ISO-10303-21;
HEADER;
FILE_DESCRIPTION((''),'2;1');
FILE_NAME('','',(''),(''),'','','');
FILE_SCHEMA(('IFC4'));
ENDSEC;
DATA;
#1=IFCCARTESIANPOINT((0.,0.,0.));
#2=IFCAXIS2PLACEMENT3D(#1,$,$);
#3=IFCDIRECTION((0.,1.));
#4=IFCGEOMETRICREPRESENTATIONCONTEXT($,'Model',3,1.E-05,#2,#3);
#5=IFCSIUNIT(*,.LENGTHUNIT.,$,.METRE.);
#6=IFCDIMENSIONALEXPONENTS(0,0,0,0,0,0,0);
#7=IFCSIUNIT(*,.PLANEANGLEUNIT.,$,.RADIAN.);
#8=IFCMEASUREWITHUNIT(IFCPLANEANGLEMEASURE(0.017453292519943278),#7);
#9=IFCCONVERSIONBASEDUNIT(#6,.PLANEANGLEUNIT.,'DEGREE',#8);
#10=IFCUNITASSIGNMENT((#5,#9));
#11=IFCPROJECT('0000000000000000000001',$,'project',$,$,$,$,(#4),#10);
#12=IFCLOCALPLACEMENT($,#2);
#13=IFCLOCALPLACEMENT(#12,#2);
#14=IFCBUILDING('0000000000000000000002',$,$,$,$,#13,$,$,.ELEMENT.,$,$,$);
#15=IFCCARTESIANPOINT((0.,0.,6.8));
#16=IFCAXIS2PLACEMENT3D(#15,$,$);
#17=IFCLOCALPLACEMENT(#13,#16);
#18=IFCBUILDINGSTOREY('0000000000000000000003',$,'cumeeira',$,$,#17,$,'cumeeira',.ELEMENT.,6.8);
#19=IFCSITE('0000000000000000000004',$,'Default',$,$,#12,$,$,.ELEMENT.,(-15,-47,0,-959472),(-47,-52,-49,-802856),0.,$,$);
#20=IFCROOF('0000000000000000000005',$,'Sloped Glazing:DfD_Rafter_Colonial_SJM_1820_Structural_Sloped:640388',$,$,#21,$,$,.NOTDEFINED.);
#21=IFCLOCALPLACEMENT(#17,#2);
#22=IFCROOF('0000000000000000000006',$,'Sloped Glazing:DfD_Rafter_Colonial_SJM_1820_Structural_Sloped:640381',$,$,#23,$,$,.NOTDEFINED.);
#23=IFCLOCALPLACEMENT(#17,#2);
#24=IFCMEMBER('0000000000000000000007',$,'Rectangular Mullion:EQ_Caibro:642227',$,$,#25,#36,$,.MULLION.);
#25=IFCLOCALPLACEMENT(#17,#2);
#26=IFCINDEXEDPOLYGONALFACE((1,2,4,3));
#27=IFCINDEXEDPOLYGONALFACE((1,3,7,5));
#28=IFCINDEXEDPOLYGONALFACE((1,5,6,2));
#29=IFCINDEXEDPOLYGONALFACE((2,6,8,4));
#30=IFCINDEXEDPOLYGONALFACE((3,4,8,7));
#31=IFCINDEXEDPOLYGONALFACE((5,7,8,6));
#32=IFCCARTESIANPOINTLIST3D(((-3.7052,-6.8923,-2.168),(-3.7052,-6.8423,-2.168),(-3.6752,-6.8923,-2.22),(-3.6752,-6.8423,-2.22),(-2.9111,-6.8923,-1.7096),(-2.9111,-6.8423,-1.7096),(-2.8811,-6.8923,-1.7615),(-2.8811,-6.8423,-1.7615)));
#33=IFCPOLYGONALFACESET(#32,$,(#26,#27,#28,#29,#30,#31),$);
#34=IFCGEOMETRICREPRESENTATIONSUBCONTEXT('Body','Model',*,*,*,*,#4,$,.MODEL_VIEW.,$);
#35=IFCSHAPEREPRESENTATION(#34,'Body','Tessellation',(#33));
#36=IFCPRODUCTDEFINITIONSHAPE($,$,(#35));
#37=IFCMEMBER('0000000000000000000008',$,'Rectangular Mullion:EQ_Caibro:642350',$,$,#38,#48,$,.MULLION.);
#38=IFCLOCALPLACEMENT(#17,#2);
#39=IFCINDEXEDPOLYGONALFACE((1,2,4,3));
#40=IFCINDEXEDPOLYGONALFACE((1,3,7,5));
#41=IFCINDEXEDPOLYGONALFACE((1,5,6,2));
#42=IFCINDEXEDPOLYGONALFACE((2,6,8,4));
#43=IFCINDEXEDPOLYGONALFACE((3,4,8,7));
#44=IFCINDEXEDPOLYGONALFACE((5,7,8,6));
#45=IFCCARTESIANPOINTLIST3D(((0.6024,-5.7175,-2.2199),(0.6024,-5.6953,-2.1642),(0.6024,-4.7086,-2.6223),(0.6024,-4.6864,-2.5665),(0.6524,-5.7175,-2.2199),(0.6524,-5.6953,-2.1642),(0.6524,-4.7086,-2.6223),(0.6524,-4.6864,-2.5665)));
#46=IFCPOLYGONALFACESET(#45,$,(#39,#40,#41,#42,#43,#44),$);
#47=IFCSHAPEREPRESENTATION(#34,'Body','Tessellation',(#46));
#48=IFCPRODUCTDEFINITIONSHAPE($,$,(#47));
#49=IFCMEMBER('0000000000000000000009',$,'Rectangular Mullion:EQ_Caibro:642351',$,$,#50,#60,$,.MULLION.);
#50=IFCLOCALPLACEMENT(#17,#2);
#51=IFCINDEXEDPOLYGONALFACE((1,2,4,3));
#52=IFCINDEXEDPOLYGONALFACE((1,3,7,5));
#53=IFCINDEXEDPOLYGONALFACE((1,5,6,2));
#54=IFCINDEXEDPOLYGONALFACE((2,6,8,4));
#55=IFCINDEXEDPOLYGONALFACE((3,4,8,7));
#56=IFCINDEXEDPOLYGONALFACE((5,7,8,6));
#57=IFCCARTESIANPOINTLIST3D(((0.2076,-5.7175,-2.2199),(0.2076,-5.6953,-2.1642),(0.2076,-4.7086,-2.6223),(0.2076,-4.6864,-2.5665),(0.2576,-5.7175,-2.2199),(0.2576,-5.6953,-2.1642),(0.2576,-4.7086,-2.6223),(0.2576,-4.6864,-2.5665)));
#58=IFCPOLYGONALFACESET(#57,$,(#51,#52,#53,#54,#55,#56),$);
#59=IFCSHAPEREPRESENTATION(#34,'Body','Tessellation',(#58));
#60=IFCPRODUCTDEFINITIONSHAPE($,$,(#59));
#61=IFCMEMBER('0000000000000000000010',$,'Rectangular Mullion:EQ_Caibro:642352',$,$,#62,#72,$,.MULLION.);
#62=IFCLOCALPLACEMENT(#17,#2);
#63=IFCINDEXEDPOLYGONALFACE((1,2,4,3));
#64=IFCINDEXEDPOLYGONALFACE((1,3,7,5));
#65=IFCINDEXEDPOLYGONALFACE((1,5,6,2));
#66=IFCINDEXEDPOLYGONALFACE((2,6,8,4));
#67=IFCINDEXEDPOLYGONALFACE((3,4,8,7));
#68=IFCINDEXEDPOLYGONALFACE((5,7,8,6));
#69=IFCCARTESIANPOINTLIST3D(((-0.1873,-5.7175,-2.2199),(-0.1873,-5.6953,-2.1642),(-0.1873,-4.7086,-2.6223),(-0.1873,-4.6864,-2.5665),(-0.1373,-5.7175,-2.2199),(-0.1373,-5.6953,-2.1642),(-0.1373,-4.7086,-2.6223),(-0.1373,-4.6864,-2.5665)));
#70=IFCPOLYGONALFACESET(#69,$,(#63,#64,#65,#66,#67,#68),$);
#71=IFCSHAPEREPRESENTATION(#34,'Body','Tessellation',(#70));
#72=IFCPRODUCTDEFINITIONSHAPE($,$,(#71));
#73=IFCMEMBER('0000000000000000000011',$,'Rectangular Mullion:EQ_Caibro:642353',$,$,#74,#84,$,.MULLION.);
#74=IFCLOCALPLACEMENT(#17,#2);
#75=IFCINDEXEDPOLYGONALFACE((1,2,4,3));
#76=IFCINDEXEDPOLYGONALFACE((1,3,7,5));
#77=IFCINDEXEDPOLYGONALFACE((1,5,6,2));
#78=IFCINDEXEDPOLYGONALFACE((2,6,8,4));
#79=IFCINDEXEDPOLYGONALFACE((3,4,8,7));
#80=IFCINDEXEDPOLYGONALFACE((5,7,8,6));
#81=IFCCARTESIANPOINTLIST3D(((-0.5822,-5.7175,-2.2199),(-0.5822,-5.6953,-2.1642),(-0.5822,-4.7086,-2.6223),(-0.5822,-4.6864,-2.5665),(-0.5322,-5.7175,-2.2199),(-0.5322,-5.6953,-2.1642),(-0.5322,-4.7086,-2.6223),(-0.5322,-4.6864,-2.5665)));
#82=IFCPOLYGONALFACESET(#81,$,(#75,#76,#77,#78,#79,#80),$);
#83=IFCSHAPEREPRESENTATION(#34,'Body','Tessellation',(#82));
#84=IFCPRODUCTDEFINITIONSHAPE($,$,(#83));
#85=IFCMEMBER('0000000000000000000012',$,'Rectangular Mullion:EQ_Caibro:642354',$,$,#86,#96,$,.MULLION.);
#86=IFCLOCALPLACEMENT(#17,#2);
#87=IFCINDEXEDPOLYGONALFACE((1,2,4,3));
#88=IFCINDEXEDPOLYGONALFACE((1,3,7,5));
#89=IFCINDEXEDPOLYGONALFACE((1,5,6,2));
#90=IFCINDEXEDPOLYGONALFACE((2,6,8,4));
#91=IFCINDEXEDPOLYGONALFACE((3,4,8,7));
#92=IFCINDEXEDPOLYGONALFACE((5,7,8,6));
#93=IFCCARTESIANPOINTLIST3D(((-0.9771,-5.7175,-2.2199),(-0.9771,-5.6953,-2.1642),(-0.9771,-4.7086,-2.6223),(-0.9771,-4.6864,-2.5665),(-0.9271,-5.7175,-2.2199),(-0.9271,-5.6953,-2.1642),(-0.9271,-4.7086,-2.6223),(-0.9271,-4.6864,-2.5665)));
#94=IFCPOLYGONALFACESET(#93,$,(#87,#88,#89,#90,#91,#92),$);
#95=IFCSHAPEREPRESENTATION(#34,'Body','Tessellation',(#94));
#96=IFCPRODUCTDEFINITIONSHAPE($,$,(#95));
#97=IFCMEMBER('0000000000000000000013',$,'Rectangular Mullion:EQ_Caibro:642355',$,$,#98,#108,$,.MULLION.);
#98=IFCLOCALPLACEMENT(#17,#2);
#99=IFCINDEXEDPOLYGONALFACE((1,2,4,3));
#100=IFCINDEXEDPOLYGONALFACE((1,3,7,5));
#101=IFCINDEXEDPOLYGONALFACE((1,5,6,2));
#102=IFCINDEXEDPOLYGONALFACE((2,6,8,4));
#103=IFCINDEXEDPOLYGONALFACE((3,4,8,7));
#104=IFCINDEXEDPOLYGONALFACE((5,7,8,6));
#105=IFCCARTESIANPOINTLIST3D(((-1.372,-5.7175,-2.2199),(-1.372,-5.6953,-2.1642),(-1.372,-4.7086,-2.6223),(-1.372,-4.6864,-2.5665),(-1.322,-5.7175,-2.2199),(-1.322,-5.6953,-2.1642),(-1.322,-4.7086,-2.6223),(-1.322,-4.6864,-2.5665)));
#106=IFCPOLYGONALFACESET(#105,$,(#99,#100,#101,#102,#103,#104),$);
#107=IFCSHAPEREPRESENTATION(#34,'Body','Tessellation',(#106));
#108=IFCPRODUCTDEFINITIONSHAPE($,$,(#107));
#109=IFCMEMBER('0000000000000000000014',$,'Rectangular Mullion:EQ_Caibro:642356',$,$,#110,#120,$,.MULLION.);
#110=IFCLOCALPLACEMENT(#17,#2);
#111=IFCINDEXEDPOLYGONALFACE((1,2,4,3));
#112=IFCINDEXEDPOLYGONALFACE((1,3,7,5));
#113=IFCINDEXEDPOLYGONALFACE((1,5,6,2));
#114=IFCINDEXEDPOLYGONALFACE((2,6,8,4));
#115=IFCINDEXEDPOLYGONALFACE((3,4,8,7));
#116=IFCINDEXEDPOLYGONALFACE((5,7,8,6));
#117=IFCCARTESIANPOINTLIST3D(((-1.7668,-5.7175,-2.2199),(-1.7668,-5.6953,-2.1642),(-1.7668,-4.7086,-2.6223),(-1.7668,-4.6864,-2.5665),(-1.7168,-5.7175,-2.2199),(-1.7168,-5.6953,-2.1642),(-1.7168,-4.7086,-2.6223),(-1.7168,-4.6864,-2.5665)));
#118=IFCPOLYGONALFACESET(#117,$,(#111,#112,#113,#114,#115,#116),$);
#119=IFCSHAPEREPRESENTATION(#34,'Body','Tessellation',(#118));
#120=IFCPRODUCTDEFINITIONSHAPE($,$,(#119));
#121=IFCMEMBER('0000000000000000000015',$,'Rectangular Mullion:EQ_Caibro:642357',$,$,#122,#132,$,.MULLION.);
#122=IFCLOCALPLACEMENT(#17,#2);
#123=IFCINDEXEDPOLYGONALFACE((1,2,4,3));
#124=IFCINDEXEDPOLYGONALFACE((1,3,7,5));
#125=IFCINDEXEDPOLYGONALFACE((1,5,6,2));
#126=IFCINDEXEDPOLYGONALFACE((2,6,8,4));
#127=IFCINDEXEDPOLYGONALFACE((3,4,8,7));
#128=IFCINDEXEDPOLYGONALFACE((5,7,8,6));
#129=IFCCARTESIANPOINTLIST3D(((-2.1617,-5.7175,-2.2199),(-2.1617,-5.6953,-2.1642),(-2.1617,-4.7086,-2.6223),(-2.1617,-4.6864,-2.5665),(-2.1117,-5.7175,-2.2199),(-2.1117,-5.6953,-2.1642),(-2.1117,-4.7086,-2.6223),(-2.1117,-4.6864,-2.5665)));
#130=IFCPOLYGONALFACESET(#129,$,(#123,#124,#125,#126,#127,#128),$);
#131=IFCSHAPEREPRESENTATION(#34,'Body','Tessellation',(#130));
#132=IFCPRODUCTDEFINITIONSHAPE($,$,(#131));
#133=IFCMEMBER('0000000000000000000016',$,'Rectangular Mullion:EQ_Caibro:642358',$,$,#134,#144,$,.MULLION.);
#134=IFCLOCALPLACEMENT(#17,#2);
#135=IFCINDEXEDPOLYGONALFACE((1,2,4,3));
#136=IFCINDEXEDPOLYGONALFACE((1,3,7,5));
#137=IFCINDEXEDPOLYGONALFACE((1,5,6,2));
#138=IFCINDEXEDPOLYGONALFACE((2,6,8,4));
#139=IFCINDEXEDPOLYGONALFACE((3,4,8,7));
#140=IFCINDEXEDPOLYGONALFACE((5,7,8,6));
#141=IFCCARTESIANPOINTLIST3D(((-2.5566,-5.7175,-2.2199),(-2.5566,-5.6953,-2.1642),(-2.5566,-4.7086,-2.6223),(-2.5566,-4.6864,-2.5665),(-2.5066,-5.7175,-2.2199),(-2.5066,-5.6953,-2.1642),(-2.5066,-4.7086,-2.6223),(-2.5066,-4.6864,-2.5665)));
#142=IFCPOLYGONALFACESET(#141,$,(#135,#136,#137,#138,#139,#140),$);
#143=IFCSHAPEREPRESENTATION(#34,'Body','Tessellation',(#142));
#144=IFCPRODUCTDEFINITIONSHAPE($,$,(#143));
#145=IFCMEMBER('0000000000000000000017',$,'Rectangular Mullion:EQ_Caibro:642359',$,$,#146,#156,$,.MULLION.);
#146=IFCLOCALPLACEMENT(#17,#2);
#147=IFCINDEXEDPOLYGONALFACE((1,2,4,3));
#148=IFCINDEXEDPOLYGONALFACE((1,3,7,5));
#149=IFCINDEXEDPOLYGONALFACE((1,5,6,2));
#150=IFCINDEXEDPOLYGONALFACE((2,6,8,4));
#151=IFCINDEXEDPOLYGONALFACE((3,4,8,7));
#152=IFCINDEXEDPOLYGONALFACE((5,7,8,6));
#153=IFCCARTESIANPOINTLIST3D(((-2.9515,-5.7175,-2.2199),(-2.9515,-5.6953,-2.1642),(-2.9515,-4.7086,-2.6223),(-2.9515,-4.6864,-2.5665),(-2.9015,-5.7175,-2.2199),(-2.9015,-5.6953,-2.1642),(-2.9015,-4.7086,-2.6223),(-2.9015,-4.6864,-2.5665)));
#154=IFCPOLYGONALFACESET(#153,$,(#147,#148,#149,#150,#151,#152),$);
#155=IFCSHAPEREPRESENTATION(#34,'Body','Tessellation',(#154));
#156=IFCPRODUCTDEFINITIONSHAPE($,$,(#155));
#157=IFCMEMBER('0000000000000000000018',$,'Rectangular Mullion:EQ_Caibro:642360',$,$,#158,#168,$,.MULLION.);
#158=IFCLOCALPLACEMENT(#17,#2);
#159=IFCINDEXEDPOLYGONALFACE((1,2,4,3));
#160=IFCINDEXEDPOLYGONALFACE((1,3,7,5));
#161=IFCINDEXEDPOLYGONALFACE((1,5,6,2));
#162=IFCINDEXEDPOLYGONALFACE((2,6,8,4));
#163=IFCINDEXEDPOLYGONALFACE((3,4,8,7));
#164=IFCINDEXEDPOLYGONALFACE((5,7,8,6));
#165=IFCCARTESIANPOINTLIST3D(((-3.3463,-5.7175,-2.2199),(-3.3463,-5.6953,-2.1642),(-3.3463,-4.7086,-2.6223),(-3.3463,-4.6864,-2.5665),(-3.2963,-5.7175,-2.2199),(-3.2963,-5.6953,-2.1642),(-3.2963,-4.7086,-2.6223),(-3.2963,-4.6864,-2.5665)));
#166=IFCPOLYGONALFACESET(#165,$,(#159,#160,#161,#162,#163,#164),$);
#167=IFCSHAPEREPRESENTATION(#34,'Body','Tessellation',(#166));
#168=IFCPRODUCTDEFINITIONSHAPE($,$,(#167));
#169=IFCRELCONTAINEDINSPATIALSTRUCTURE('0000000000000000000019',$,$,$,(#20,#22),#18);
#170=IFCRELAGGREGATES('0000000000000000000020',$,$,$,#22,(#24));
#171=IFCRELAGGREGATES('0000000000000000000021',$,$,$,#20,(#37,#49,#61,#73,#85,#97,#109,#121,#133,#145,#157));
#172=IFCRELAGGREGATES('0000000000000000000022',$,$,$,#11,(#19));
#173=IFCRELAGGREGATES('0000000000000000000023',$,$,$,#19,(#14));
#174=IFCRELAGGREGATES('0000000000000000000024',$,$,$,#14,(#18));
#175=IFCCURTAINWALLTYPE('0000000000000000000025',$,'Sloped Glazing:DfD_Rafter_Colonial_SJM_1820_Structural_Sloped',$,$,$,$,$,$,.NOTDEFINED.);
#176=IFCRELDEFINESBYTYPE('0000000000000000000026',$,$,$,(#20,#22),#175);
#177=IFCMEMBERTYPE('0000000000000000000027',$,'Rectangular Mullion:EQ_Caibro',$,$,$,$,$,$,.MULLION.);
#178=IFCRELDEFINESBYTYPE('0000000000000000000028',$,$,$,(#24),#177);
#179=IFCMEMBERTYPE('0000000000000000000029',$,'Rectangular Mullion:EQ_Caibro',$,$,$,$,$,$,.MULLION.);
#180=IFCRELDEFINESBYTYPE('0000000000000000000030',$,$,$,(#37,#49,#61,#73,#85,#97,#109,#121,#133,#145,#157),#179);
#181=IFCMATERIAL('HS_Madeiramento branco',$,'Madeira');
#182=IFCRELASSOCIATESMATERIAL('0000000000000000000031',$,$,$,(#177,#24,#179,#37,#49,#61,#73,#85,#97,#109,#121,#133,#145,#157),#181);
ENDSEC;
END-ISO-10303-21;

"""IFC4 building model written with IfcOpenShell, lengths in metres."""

from ifc_helpers import new_model, entity, si_unit, converted_unit, direction, frame, origin, place, context, subcontext, project, spatial, indexed_curve, outline, extrude, source, transform, mapped, material, type_object, type_shapes, element, aggregate, save


model = new_model("IFC4")

# Units and contexts
model_context = context("Model", 3, precision=1e-05, world=origin(), true_north=direction((0.0, 1.0)))
body_context = subcontext(model_context, "Body", "Model", "MODEL_VIEW")
ifc_project = project(units=[si_unit("LENGTHUNIT", "METRE"), converted_unit("PLANEANGLEUNIT", "DEGREE", entity("IfcPlaneAngleMeasure", 0.017453292519943278), si_unit("PLANEANGLEUNIT", "RADIAN"), dimensions=[0, 0, 0, 0, 0, 0, 0])], contexts=[model_context])

# Site, building, storey
site_placement = place(None, origin())
site = spatial("IfcSite", under=ifc_project, at=site_placement, Name="Default", CompositionType="ELEMENT", RefLatitude=(-15, -47, 0, -959472), RefLongitude=(-47, -52, -49, -802856), RefElevation=0.0)
building_placement = place(site_placement, origin())
building = spatial("IfcBuilding", under=site, at=building_placement, CompositionType="ELEMENT")
storey_placement = place(building_placement, frame((0.0, 0.0, 6.8)))
storey = spatial("IfcBuildingStorey", under=building, at=storey_placement, Name="cumeeira", LongName="cumeeira", CompositionType="ELEMENT", Elevation=6.8)

# Roofs, member
curtain_wall_type = type_object("IfcCurtainWallType", Name="Sloped Glazing:DfD_Rafter_Colonial_SJM_1820_Structural_Sloped", PredefinedType="NOTDEFINED")
roof_1_placement = place(storey_placement, frame((0.0, 0.0, -6.8)))
roof_1 = element("IfcRoof", 1, at=roof_1_placement, inside=storey, type_object=curtain_wall_type, Name="Sloped Glazing:DfD_Rafter_Colonial_SJM_1820_Structural_Sloped:640388", PredefinedType="NOTDEFINED")
ifc_material = material(Name="HS_Madeiramento branco", Category="Madeira")
roof_2_placement = place(storey_placement, frame((0.0, 0.0, -6.8)))
roof_2 = element("IfcRoof", 2, at=roof_2_placement, inside=storey, type_object=curtain_wall_type, Name="Sloped Glazing:DfD_Rafter_Colonial_SJM_1820_Structural_Sloped:640381", PredefinedType="NOTDEFINED")
member_type_1 = type_object("IfcMemberType", Name="Rectangular Mullion:EQ_Caibro", PredefinedType="MULLION", material=ifc_material)
shared_shape_1 = source(origin(), body_context, "Body", "SweptSolid", [
    extrude(outline(indexed_curve([(-0.025, -0.03), (0.025, -0.03), (0.025, 0.03), (-0.025, 0.03), (-0.025, -0.03)], self_intersect=False)), frame((0.0, -0.03, -0.917), z_axis=(0.0, 0.0, 1.0), x_axis=(-1.0, 0.0, 0.0)), (0.0, 0.0, 1.0), 0.917),
])
type_shapes(member_type_1, [shared_shape_1])
member_1_placement = place(roof_2_placement, frame((-2.8811, -6.8673, 5.0385), z_axis=(0.866025, 0.0, 0.5), x_axis=(0.0, -1.0, 0.0)))
member_1 = element("IfcMember", 3, at=member_1_placement, type_object=member_type_1, material=ifc_material, Name="Rectangular Mullion:EQ_Caibro:642227", PredefinedType="MULLION", context=body_context, shape_type="MappedRepresentation", body=[
    mapped(shared_shape_1, transform((0.0, 0.0, 0.0), scale=1.0)),
])
aggregate(roof_2, [member_1])

# Members
member_type_2 = type_object("IfcMemberType", Name="Rectangular Mullion:EQ_Caibro", PredefinedType="MULLION", material=ifc_material)
shared_shape_2 = source(origin(), body_context, "Body", "SweptSolid", [
    extrude(outline(indexed_curve([(-0.025, -0.03), (0.025, -0.03), (0.025, 0.03), (-0.025, 0.03), (-0.025, -0.03)], self_intersect=False)), frame((0.0, -0.03, -1.0862), z_axis=(0.0, 0.0, 1.0), x_axis=(-1.0, 0.0, 0.0)), (0.0, 0.0, 1.0), 1.0862),
])
type_shapes(member_type_2, [shared_shape_2])
member_2_placement = place(roof_1_placement, frame((0.6274, -5.7175, 4.5801), z_axis=(0.0, -0.928874, 0.370395), x_axis=(-1.0, 0.0, 0.0)))
member_2 = element("IfcMember", 4, at=member_2_placement, type_object=member_type_2, material=ifc_material, Name="Rectangular Mullion:EQ_Caibro:642350", PredefinedType="MULLION", context=body_context, shape_type="MappedRepresentation", body=[
    mapped(shared_shape_2, transform((0.0, 0.0, 0.0), scale=1.0)),
])
member_3_placement = place(roof_1_placement, frame((0.2326, -5.7175, 4.5801), z_axis=(0.0, -0.928874, 0.370395), x_axis=(-1.0, 0.0, 0.0)))
member_3 = element("IfcMember", 5, at=member_3_placement, type_object=member_type_2, material=ifc_material, Name="Rectangular Mullion:EQ_Caibro:642351", PredefinedType="MULLION", context=body_context, shape_type="MappedRepresentation", body=[
    mapped(shared_shape_2, transform((0.0, 0.0, 0.0), scale=1.0)),
])
member_4_placement = place(roof_1_placement, frame((-0.1623, -5.7175, 4.5801), z_axis=(0.0, -0.928874, 0.370395), x_axis=(-1.0, 0.0, 0.0)))
member_4 = element("IfcMember", 6, at=member_4_placement, type_object=member_type_2, material=ifc_material, Name="Rectangular Mullion:EQ_Caibro:642352", PredefinedType="MULLION", context=body_context, shape_type="MappedRepresentation", body=[
    mapped(shared_shape_2, transform((0.0, 0.0, 0.0), scale=1.0)),
])
member_5_placement = place(roof_1_placement, frame((-0.5572, -5.7175, 4.5801), z_axis=(0.0, -0.928874, 0.370395), x_axis=(-1.0, 0.0, 0.0)))
member_5 = element("IfcMember", 7, at=member_5_placement, type_object=member_type_2, material=ifc_material, Name="Rectangular Mullion:EQ_Caibro:642353", PredefinedType="MULLION", context=body_context, shape_type="MappedRepresentation", body=[
    mapped(shared_shape_2, transform((0.0, 0.0, 0.0), scale=1.0)),
])
member_6_placement = place(roof_1_placement, frame((-0.9521, -5.7175, 4.5801), z_axis=(0.0, -0.928874, 0.370395), x_axis=(-1.0, 0.0, 0.0)))
member_6 = element("IfcMember", 8, at=member_6_placement, type_object=member_type_2, material=ifc_material, Name="Rectangular Mullion:EQ_Caibro:642354", PredefinedType="MULLION", context=body_context, shape_type="MappedRepresentation", body=[
    mapped(shared_shape_2, transform((0.0, 0.0, 0.0), scale=1.0)),
])
member_7_placement = place(roof_1_placement, frame((-1.347, -5.7175, 4.5801), z_axis=(0.0, -0.928874, 0.370395), x_axis=(-1.0, 0.0, 0.0)))
member_7 = element("IfcMember", 9, at=member_7_placement, type_object=member_type_2, material=ifc_material, Name="Rectangular Mullion:EQ_Caibro:642355", PredefinedType="MULLION", context=body_context, shape_type="MappedRepresentation", body=[
    mapped(shared_shape_2, transform((0.0, 0.0, 0.0), scale=1.0)),
])
member_8_placement = place(roof_1_placement, frame((-1.7418, -5.7175, 4.5801), z_axis=(0.0, -0.928874, 0.370395), x_axis=(-1.0, 0.0, 0.0)))
member_8 = element("IfcMember", 10, at=member_8_placement, type_object=member_type_2, material=ifc_material, Name="Rectangular Mullion:EQ_Caibro:642356", PredefinedType="MULLION", context=body_context, shape_type="MappedRepresentation", body=[
    mapped(shared_shape_2, transform((0.0, 0.0, 0.0), scale=1.0)),
])
member_9_placement = place(roof_1_placement, frame((-2.1367, -5.7175, 4.5801), z_axis=(0.0, -0.928874, 0.370395), x_axis=(-1.0, 0.0, 0.0)))
member_9 = element("IfcMember", 11, at=member_9_placement, type_object=member_type_2, material=ifc_material, Name="Rectangular Mullion:EQ_Caibro:642357", PredefinedType="MULLION", context=body_context, shape_type="MappedRepresentation", body=[
    mapped(shared_shape_2, transform((0.0, 0.0, 0.0), scale=1.0)),
])
member_10_placement = place(roof_1_placement, frame((-2.5316, -5.7175, 4.5801), z_axis=(0.0, -0.928874, 0.370395), x_axis=(-1.0, 0.0, 0.0)))
member_10 = element("IfcMember", 12, at=member_10_placement, type_object=member_type_2, material=ifc_material, Name="Rectangular Mullion:EQ_Caibro:642358", PredefinedType="MULLION", context=body_context, shape_type="MappedRepresentation", body=[
    mapped(shared_shape_2, transform((0.0, 0.0, 0.0), scale=1.0)),
])
member_11_placement = place(roof_1_placement, frame((-2.9265, -5.7175, 4.5801), z_axis=(0.0, -0.928874, 0.370395), x_axis=(-1.0, 0.0, 0.0)))
member_11 = element("IfcMember", 13, at=member_11_placement, type_object=member_type_2, material=ifc_material, Name="Rectangular Mullion:EQ_Caibro:642359", PredefinedType="MULLION", context=body_context, shape_type="MappedRepresentation", body=[
    mapped(shared_shape_2, transform((0.0, 0.0, 0.0), scale=1.0)),
])
member_12_placement = place(roof_1_placement, frame((-3.3213, -5.7175, 4.5801), z_axis=(0.0, -0.928874, 0.370395), x_axis=(-1.0, 0.0, 0.0)))
member_12 = element("IfcMember", 14, at=member_12_placement, type_object=member_type_2, material=ifc_material, Name="Rectangular Mullion:EQ_Caibro:642360", PredefinedType="MULLION", context=body_context, shape_type="MappedRepresentation", body=[
    mapped(shared_shape_2, transform((0.0, 0.0, 0.0), scale=1.0)),
])
aggregate(roof_1, [member_2, member_3, member_4, member_5, member_6, member_7, member_8, member_9, member_10, member_11, member_12])

save(model, "model.ifc")
